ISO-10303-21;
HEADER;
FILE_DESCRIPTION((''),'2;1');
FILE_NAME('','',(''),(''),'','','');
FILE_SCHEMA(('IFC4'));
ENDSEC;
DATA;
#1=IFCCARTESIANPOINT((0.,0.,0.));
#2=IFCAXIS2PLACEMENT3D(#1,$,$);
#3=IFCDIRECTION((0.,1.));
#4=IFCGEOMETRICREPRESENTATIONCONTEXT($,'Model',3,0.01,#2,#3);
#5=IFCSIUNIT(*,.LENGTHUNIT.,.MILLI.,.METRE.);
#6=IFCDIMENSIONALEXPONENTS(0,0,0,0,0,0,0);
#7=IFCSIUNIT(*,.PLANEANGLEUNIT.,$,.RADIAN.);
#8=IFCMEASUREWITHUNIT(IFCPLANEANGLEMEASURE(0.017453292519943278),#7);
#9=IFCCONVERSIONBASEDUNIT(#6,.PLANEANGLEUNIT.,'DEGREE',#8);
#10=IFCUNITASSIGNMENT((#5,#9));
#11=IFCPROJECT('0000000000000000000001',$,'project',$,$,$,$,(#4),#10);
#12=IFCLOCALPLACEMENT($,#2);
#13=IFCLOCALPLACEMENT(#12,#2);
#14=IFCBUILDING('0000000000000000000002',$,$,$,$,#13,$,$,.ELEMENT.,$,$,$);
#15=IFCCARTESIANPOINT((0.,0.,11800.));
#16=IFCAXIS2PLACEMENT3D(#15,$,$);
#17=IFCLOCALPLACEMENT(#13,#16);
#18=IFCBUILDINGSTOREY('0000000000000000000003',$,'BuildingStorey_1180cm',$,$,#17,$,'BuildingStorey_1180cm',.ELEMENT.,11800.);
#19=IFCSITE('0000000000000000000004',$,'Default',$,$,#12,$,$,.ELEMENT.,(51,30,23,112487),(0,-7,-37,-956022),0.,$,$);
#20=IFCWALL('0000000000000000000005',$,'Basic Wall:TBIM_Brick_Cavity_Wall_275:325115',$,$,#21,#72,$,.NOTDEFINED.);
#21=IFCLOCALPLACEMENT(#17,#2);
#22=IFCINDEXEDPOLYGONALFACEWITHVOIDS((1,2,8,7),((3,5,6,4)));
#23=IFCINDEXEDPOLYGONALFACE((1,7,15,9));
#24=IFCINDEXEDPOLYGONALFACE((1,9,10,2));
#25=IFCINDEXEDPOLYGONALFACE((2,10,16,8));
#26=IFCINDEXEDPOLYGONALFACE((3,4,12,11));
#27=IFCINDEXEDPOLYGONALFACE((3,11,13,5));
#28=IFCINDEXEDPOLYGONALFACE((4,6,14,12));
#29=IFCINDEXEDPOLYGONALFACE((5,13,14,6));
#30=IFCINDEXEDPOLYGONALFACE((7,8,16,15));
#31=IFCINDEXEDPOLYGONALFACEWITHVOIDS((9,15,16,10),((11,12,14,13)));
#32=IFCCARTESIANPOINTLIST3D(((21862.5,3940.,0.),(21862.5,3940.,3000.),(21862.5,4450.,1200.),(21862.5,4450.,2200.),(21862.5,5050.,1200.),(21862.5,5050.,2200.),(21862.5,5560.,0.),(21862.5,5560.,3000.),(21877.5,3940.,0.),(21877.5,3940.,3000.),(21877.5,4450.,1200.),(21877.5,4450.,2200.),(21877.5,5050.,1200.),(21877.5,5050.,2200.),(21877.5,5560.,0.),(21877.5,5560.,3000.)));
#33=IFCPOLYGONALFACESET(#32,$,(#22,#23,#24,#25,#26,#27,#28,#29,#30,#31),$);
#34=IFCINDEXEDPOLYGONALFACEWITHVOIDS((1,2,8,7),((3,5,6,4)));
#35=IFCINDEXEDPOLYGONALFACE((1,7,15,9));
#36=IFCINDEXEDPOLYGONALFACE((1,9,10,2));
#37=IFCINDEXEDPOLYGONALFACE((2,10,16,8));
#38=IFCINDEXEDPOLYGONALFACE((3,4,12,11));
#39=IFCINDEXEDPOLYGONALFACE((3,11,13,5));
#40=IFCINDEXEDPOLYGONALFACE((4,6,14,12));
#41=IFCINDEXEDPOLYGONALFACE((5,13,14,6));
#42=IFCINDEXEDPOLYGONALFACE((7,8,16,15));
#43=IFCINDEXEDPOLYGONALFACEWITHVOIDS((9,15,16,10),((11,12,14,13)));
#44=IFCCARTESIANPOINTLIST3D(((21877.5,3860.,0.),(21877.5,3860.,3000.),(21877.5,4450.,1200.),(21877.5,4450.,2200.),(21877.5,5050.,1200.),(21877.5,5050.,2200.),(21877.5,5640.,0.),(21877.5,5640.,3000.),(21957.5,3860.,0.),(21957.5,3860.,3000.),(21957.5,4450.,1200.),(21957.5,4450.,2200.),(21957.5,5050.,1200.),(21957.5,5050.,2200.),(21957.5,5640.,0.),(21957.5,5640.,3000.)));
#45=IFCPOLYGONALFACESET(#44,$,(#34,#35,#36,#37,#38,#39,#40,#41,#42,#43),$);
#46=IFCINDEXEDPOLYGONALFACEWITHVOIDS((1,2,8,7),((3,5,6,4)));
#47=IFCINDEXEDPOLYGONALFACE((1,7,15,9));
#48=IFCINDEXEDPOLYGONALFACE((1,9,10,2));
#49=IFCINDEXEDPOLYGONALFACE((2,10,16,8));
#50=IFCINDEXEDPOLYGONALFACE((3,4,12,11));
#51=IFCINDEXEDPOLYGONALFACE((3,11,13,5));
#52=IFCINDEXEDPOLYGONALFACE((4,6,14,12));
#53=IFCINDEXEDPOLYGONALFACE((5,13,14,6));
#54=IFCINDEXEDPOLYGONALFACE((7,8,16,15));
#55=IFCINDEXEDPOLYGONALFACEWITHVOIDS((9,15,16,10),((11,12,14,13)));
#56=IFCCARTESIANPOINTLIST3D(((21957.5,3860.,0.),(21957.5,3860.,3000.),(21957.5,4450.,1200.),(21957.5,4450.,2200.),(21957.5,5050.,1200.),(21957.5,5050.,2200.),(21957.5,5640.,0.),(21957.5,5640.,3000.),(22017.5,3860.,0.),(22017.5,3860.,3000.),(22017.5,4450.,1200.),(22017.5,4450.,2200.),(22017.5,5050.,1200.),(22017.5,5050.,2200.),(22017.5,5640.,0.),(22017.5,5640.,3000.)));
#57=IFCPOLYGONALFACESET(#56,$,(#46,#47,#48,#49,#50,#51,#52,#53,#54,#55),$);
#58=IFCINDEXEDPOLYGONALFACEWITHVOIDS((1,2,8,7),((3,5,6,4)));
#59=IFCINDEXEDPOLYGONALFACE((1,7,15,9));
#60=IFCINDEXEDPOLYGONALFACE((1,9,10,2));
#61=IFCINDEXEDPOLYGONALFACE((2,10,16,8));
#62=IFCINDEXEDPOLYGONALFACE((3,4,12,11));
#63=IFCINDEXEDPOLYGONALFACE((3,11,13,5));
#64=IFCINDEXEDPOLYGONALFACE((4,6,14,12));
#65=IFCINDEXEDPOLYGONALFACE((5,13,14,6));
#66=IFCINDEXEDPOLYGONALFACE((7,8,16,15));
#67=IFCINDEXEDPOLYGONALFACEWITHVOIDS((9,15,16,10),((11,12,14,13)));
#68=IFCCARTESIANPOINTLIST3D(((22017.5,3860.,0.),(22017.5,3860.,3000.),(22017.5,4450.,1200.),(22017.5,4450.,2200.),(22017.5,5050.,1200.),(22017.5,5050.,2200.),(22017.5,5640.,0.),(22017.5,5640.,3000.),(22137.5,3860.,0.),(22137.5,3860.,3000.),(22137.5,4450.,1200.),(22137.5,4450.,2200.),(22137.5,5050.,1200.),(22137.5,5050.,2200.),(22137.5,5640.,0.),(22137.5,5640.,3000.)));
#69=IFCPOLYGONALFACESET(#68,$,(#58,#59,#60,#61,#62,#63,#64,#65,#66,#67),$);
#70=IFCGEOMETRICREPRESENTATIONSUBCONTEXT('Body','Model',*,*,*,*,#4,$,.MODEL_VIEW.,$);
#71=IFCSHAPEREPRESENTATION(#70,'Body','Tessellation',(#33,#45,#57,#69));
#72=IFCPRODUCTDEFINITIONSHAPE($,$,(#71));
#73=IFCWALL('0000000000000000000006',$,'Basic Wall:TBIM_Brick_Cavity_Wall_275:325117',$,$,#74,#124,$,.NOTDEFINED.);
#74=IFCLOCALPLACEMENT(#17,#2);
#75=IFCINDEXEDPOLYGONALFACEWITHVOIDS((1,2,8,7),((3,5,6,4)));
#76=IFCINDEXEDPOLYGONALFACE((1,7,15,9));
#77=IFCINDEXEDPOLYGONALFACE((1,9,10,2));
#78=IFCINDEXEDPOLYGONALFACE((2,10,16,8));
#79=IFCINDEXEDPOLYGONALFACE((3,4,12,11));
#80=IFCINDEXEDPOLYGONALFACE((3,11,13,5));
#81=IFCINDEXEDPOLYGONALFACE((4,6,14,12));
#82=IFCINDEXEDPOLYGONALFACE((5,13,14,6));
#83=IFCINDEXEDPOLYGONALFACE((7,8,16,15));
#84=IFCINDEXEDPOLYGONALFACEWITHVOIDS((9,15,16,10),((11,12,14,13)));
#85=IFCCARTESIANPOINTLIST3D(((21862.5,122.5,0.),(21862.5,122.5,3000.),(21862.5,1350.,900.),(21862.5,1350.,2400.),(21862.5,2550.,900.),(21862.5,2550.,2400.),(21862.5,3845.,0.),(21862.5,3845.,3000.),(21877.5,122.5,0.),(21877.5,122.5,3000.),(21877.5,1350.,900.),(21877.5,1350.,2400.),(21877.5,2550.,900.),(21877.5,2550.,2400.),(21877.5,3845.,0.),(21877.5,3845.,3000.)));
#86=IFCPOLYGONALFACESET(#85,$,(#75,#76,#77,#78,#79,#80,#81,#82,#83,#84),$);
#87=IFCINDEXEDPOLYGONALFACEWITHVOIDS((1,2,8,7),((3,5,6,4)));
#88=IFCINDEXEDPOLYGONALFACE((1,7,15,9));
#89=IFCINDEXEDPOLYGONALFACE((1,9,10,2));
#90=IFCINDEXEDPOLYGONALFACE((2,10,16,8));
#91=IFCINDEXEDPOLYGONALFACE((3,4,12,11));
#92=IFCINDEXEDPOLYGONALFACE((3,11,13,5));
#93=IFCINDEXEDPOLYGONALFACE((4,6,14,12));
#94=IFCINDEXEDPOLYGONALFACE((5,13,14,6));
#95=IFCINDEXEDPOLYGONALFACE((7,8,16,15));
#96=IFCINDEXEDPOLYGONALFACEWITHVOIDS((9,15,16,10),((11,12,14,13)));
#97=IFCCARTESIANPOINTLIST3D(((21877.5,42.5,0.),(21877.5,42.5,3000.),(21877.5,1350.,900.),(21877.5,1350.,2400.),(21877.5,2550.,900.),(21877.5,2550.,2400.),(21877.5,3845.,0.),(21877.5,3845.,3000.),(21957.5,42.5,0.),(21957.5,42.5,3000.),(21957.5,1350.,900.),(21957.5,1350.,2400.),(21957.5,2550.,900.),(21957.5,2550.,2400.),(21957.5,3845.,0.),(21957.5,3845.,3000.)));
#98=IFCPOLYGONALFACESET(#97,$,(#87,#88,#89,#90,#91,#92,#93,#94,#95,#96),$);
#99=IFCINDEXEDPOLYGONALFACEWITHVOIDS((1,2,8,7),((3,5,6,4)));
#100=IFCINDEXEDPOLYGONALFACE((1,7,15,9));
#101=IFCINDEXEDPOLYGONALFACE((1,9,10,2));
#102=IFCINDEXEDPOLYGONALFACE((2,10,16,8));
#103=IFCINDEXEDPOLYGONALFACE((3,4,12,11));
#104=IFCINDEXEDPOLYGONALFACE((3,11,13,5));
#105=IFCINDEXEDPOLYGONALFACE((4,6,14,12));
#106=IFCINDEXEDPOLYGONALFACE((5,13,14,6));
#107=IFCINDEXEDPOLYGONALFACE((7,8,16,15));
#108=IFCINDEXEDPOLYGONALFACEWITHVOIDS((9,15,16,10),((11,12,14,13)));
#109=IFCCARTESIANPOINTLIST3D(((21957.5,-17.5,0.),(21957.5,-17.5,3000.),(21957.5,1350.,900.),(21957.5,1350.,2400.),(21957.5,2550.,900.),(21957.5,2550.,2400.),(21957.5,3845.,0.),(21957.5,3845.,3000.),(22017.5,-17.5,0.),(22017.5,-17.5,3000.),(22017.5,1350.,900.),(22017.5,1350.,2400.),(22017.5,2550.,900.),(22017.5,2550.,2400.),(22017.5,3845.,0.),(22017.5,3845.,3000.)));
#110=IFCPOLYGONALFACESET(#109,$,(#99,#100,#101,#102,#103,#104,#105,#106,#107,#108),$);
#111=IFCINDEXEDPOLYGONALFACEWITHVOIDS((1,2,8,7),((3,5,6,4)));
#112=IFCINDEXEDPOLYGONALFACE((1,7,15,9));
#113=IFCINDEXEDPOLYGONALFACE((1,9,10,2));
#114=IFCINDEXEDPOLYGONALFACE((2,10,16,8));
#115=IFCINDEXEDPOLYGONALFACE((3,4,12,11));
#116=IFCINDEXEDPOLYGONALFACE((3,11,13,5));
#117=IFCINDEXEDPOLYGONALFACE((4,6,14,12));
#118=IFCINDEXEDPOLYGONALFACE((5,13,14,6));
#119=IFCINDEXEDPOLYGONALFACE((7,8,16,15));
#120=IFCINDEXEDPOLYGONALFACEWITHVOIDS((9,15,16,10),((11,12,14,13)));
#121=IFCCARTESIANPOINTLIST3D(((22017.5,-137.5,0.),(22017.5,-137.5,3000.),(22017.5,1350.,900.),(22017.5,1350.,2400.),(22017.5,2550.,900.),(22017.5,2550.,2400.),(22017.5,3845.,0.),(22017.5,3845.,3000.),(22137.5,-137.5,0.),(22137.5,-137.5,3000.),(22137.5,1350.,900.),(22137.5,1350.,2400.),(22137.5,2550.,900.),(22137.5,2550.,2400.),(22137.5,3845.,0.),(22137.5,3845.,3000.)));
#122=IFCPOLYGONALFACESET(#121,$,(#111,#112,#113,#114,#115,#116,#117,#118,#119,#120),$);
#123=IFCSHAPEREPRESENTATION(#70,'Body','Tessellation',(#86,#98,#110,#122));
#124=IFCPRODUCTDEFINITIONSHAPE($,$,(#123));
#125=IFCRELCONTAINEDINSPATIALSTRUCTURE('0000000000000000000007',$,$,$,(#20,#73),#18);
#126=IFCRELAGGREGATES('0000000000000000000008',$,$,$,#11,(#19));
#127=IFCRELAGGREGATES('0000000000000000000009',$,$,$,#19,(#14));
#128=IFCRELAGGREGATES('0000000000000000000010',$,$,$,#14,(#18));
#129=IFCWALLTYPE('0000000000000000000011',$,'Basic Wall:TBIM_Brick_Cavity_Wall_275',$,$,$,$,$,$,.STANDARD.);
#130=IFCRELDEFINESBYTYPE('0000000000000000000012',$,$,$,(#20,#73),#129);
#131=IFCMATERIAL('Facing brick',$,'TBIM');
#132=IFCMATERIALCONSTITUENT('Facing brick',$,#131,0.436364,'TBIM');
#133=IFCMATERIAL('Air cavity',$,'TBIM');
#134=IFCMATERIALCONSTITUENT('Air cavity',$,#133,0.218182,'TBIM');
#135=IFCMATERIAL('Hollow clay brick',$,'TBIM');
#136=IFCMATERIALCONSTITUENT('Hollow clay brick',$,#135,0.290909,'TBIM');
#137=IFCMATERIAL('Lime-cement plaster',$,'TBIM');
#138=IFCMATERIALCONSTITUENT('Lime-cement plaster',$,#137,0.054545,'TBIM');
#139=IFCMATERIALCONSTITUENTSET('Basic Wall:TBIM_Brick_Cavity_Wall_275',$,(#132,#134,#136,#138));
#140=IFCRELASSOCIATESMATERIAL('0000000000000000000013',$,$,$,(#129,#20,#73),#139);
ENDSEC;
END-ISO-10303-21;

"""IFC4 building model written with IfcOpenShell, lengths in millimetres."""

from ifc_helpers import new_model, entity, si_unit, converted_unit, direction, frame, origin, place, context, subcontext, project, spatial, indexed_curve, outline, extrude, material, constituent, constituent_set, type_object, element, save


model = new_model("IFC4")

# Units and contexts
model_context = context("Model", 3, precision=0.01, world=origin(), true_north=direction((0.0, 1.0)))
body_context = subcontext(model_context, "Body", "Model", "MODEL_VIEW")
ifc_project = project(units=[si_unit("LENGTHUNIT", "METRE", prefix="MILLI"), converted_unit("PLANEANGLEUNIT", "DEGREE", entity("IfcPlaneAngleMeasure", 0.017453292519943278), si_unit("PLANEANGLEUNIT", "RADIAN"), dimensions=[0, 0, 0, 0, 0, 0, 0])], contexts=[model_context])

# Site, building, storey
site_placement = place(None, origin())
site = spatial("IfcSite", under=ifc_project, at=site_placement, Name="Default", CompositionType="ELEMENT", RefLatitude=(51, 30, 23, 112487), RefLongitude=(0, -7, -37, -956022), RefElevation=0.0)
building_placement = place(site_placement, origin())
building = spatial("IfcBuilding", under=site, at=building_placement, CompositionType="ELEMENT")
storey_placement = place(building_placement, frame((0.0, 0.0, 11800.0)))
storey = spatial("IfcBuildingStorey", under=building, at=storey_placement, Name="BuildingStorey_1180cm", LongName="BuildingStorey_1180cm", CompositionType="ELEMENT", Elevation=11800.0)

# Walls, openings
ifc_material_1 = material(Name="Facing brick", Category="TBIM")
ifc_constituent_1 = constituent(ifc_material_1, Name="Facing brick", Category="TBIM", fraction=0.436364)
ifc_material_2 = material(Name="Air cavity", Category="TBIM")
ifc_constituent_2 = constituent(ifc_material_2, Name="Air cavity", Category="TBIM", fraction=0.218182)
ifc_material_3 = material(Name="Hollow clay brick", Category="TBIM")
ifc_constituent_3 = constituent(ifc_material_3, Name="Hollow clay brick", Category="TBIM", fraction=0.290909)
ifc_material_4 = material(Name="Lime-cement plaster", Category="TBIM")
ifc_constituent_4 = constituent(ifc_material_4, Name="Lime-cement plaster", Category="TBIM", fraction=0.054545)
ifc_constituent_set_1 = constituent_set(constituents=[ifc_constituent_1, ifc_constituent_2, ifc_constituent_3, ifc_constituent_4], Name="Basic Wall:TBIM_Brick_Cavity_Wall_275")
wall_type_1 = type_object("IfcWallType", Name="Basic Wall:TBIM_Brick_Cavity_Wall_275", PredefinedType="STANDARD", material=ifc_constituent_set_1)
wall_1_placement = place(storey_placement, frame((22000.0, 5655.0, 0.0), z_axis=(0.0, 0.0, 1.0), x_axis=(0.0, -1.0, 0.0)))
wall_1 = element("IfcWall", 1, at=wall_1_placement, inside=storey, type_object=wall_type_1, material=ifc_constituent_set_1, Name="Basic Wall:TBIM_Brick_Cavity_Wall_275:325115", PredefinedType="NOTDEFINED", context=body_context, shape_type="SweptSolid", body=[
    extrude(outline(indexed_curve([(-1500.0, -810.0), (1500.0, -810.0), (1500.0, -795.0), (1500.0, 795.0), (1500.0, 810.0), (-1500.0, 810.0), (-1500.0, 795.0), (-1500.0, -795.0), (-1500.0, -810.0)], self_intersect=False), holes=[indexed_curve([(700.0, -300.0), (-300.0, -300.0), (-300.0, 300.0), (700.0, 300.0), (700.0, -300.0)], self_intersect=False)]), frame((905.0, -137.5, 1500.0), z_axis=(0.0, 1.0, 0.0), x_axis=(0.0, 0.0, 1.0)), (0.0, 0.0, 1.0), 15.0),
    extrude(outline(indexed_curve([(-1500.0, -890.0), (1500.0, -890.0), (1500.0, 890.0), (-1500.0, 890.0), (-1500.0, -890.0)], self_intersect=False), holes=[indexed_curve([(-300.0, -300.0), (-300.0, 300.0), (700.0, 300.0), (700.0, -300.0), (-300.0, -300.0)], self_intersect=False)]), frame((905.0, -122.5, 1500.0), z_axis=(0.0, 1.0, 0.0), x_axis=(0.0, 0.0, 1.0)), (0.0, 0.0, 1.0), 80.0),
    extrude(outline(indexed_curve([(-1500.0, -890.0), (1500.0, -890.0), (1500.0, 890.0), (-1500.0, 890.0), (-1500.0, -890.0)], self_intersect=False), holes=[indexed_curve([(-300.0, -300.0), (-300.0, 300.0), (700.0, 300.0), (700.0, -300.0), (-300.0, -300.0)], self_intersect=False)]), frame((905.0, -42.5, 1500.0), z_axis=(0.0, 1.0, 0.0), x_axis=(0.0, 0.0, 1.0)), (0.0, 0.0, 1.0), 60.0),
    extrude(outline(indexed_curve([(-1500.0, -890.0), (1500.0, -890.0), (1500.0, 890.0), (-1500.0, 890.0), (-1500.0, -890.0)], self_intersect=False), holes=[indexed_curve([(-300.0, -300.0), (-300.0, 300.0), (700.0, 300.0), (700.0, -300.0), (-300.0, -300.0)], self_intersect=False)]), frame((905.0, 17.5, 1500.0), z_axis=(0.0, 1.0, 0.0), x_axis=(0.0, 0.0, 1.0)), (0.0, 0.0, 1.0), 120.0),
])
opening_1_placement = place(wall_1_placement, frame((605.0, -137.5, 1200.0)))
element("IfcOpeningElement", 2, at=opening_1_placement, cuts=wall_1, PredefinedType="OPENING", context=body_context, shape_type="SweptSolid", body=[
    extrude(outline(indexed_curve([(1000.0, 0.0), (1000.0, 600.0), (0.0, 600.0), (0.0, 0.0), (1000.0, 0.0)], self_intersect=False)), frame((0.0, 0.0, 0.0), z_axis=(0.0, 1.0, 0.0), x_axis=(0.0, 0.0, 1.0)), (0.0, 0.0, 1.0), 275.0),
])
wall_2_placement = place(storey_placement, frame((22000.0, -137.5, 0.0), z_axis=(0.0, 0.0, 1.0), x_axis=(0.0, 1.0, 0.0)))
wall_2 = element("IfcWall", 3, at=wall_2_placement, inside=storey, type_object=wall_type_1, material=ifc_constituent_set_1, Name="Basic Wall:TBIM_Brick_Cavity_Wall_275:325117", PredefinedType="NOTDEFINED", context=body_context, shape_type="SweptSolid", body=[
    extrude(outline(indexed_curve([(-1245.8, -1500.0), (-1230.8, -1500.0), (2476.7, -1500.0), (2476.7, 1500.0), (-1230.8, 1500.0), (-1245.8, 1500.0), (-1245.8, -1500.0)], self_intersect=False), holes=[indexed_curve([(-18.3, 900.0), (1181.7, 900.0), (1181.7, -600.0), (-18.3, -600.0), (-18.3, 900.0)], self_intersect=False)]), frame((1505.8, 137.5, 1500.0), z_axis=(0.0, -1.0, 0.0), x_axis=(1.0, 0.0, 0.0)), (0.0, 0.0, 1.0), 15.0),
    extrude(outline(indexed_curve([(-1500.0, -1901.3), (1500.0, -1901.3), (1500.0, 1901.3), (-1500.0, 1901.3), (-1500.0, -1901.3)], self_intersect=False), holes=[indexed_curve([(900.0, 593.8), (900.0, -606.2), (-600.0, -606.2), (-600.0, 593.8), (900.0, 593.8)], self_intersect=False)]), frame((2081.3, 122.5, 1500.0), z_axis=(0.0, -1.0, 0.0), x_axis=(0.0, 0.0, 1.0)), (0.0, 0.0, 1.0), 80.0),
    extrude(outline(indexed_curve([(-1500.0, -1931.3), (1500.0, -1931.3), (1500.0, 1931.3), (-1500.0, 1931.2), (-1500.0, -1931.3)], self_intersect=False), holes=[indexed_curve([(900.0, 563.8), (900.0, -636.2), (-600.0, -636.2), (-600.0, 563.8), (900.0, 563.8)], self_intersect=False)]), frame((2051.3, 42.5, 1500.0), z_axis=(0.0, -1.0, 0.0), x_axis=(0.0, 0.0, 1.0)), (0.0, 0.0, 1.0), 60.0),
    extrude(outline(indexed_curve([(-1500.0, -1991.3), (1500.0, -1991.3), (1500.0, 1991.3), (-1500.0, 1991.3), (-1500.0, -1991.3)], self_intersect=False), holes=[indexed_curve([(900.0, 503.8), (900.0, -696.2), (-600.0, -696.2), (-600.0, 503.8), (900.0, 503.8)], self_intersect=False)]), frame((1991.3, -17.5, 1500.0), z_axis=(0.0, -1.0, 0.0), x_axis=(0.0, 0.0, 1.0)), (0.0, 0.0, 1.0), 120.0),
])
opening_2_placement = place(wall_2_placement, frame((1487.5, -137.5, 900.0)))
element("IfcOpeningElement", 4, at=opening_2_placement, cuts=wall_2, PredefinedType="OPENING", context=body_context, shape_type="SweptSolid", body=[
    extrude(outline(indexed_curve([(1500.0, 0.0), (1500.0, 1200.0), (0.0, 1200.0), (0.0, 0.0), (1500.0, 0.0)], self_intersect=False)), frame((0.0, 0.0, 0.0), z_axis=(0.0, 1.0, 0.0), x_axis=(0.0, 0.0, 1.0)), (0.0, 0.0, 1.0), 275.0),
])

save(model, "model.ifc")
